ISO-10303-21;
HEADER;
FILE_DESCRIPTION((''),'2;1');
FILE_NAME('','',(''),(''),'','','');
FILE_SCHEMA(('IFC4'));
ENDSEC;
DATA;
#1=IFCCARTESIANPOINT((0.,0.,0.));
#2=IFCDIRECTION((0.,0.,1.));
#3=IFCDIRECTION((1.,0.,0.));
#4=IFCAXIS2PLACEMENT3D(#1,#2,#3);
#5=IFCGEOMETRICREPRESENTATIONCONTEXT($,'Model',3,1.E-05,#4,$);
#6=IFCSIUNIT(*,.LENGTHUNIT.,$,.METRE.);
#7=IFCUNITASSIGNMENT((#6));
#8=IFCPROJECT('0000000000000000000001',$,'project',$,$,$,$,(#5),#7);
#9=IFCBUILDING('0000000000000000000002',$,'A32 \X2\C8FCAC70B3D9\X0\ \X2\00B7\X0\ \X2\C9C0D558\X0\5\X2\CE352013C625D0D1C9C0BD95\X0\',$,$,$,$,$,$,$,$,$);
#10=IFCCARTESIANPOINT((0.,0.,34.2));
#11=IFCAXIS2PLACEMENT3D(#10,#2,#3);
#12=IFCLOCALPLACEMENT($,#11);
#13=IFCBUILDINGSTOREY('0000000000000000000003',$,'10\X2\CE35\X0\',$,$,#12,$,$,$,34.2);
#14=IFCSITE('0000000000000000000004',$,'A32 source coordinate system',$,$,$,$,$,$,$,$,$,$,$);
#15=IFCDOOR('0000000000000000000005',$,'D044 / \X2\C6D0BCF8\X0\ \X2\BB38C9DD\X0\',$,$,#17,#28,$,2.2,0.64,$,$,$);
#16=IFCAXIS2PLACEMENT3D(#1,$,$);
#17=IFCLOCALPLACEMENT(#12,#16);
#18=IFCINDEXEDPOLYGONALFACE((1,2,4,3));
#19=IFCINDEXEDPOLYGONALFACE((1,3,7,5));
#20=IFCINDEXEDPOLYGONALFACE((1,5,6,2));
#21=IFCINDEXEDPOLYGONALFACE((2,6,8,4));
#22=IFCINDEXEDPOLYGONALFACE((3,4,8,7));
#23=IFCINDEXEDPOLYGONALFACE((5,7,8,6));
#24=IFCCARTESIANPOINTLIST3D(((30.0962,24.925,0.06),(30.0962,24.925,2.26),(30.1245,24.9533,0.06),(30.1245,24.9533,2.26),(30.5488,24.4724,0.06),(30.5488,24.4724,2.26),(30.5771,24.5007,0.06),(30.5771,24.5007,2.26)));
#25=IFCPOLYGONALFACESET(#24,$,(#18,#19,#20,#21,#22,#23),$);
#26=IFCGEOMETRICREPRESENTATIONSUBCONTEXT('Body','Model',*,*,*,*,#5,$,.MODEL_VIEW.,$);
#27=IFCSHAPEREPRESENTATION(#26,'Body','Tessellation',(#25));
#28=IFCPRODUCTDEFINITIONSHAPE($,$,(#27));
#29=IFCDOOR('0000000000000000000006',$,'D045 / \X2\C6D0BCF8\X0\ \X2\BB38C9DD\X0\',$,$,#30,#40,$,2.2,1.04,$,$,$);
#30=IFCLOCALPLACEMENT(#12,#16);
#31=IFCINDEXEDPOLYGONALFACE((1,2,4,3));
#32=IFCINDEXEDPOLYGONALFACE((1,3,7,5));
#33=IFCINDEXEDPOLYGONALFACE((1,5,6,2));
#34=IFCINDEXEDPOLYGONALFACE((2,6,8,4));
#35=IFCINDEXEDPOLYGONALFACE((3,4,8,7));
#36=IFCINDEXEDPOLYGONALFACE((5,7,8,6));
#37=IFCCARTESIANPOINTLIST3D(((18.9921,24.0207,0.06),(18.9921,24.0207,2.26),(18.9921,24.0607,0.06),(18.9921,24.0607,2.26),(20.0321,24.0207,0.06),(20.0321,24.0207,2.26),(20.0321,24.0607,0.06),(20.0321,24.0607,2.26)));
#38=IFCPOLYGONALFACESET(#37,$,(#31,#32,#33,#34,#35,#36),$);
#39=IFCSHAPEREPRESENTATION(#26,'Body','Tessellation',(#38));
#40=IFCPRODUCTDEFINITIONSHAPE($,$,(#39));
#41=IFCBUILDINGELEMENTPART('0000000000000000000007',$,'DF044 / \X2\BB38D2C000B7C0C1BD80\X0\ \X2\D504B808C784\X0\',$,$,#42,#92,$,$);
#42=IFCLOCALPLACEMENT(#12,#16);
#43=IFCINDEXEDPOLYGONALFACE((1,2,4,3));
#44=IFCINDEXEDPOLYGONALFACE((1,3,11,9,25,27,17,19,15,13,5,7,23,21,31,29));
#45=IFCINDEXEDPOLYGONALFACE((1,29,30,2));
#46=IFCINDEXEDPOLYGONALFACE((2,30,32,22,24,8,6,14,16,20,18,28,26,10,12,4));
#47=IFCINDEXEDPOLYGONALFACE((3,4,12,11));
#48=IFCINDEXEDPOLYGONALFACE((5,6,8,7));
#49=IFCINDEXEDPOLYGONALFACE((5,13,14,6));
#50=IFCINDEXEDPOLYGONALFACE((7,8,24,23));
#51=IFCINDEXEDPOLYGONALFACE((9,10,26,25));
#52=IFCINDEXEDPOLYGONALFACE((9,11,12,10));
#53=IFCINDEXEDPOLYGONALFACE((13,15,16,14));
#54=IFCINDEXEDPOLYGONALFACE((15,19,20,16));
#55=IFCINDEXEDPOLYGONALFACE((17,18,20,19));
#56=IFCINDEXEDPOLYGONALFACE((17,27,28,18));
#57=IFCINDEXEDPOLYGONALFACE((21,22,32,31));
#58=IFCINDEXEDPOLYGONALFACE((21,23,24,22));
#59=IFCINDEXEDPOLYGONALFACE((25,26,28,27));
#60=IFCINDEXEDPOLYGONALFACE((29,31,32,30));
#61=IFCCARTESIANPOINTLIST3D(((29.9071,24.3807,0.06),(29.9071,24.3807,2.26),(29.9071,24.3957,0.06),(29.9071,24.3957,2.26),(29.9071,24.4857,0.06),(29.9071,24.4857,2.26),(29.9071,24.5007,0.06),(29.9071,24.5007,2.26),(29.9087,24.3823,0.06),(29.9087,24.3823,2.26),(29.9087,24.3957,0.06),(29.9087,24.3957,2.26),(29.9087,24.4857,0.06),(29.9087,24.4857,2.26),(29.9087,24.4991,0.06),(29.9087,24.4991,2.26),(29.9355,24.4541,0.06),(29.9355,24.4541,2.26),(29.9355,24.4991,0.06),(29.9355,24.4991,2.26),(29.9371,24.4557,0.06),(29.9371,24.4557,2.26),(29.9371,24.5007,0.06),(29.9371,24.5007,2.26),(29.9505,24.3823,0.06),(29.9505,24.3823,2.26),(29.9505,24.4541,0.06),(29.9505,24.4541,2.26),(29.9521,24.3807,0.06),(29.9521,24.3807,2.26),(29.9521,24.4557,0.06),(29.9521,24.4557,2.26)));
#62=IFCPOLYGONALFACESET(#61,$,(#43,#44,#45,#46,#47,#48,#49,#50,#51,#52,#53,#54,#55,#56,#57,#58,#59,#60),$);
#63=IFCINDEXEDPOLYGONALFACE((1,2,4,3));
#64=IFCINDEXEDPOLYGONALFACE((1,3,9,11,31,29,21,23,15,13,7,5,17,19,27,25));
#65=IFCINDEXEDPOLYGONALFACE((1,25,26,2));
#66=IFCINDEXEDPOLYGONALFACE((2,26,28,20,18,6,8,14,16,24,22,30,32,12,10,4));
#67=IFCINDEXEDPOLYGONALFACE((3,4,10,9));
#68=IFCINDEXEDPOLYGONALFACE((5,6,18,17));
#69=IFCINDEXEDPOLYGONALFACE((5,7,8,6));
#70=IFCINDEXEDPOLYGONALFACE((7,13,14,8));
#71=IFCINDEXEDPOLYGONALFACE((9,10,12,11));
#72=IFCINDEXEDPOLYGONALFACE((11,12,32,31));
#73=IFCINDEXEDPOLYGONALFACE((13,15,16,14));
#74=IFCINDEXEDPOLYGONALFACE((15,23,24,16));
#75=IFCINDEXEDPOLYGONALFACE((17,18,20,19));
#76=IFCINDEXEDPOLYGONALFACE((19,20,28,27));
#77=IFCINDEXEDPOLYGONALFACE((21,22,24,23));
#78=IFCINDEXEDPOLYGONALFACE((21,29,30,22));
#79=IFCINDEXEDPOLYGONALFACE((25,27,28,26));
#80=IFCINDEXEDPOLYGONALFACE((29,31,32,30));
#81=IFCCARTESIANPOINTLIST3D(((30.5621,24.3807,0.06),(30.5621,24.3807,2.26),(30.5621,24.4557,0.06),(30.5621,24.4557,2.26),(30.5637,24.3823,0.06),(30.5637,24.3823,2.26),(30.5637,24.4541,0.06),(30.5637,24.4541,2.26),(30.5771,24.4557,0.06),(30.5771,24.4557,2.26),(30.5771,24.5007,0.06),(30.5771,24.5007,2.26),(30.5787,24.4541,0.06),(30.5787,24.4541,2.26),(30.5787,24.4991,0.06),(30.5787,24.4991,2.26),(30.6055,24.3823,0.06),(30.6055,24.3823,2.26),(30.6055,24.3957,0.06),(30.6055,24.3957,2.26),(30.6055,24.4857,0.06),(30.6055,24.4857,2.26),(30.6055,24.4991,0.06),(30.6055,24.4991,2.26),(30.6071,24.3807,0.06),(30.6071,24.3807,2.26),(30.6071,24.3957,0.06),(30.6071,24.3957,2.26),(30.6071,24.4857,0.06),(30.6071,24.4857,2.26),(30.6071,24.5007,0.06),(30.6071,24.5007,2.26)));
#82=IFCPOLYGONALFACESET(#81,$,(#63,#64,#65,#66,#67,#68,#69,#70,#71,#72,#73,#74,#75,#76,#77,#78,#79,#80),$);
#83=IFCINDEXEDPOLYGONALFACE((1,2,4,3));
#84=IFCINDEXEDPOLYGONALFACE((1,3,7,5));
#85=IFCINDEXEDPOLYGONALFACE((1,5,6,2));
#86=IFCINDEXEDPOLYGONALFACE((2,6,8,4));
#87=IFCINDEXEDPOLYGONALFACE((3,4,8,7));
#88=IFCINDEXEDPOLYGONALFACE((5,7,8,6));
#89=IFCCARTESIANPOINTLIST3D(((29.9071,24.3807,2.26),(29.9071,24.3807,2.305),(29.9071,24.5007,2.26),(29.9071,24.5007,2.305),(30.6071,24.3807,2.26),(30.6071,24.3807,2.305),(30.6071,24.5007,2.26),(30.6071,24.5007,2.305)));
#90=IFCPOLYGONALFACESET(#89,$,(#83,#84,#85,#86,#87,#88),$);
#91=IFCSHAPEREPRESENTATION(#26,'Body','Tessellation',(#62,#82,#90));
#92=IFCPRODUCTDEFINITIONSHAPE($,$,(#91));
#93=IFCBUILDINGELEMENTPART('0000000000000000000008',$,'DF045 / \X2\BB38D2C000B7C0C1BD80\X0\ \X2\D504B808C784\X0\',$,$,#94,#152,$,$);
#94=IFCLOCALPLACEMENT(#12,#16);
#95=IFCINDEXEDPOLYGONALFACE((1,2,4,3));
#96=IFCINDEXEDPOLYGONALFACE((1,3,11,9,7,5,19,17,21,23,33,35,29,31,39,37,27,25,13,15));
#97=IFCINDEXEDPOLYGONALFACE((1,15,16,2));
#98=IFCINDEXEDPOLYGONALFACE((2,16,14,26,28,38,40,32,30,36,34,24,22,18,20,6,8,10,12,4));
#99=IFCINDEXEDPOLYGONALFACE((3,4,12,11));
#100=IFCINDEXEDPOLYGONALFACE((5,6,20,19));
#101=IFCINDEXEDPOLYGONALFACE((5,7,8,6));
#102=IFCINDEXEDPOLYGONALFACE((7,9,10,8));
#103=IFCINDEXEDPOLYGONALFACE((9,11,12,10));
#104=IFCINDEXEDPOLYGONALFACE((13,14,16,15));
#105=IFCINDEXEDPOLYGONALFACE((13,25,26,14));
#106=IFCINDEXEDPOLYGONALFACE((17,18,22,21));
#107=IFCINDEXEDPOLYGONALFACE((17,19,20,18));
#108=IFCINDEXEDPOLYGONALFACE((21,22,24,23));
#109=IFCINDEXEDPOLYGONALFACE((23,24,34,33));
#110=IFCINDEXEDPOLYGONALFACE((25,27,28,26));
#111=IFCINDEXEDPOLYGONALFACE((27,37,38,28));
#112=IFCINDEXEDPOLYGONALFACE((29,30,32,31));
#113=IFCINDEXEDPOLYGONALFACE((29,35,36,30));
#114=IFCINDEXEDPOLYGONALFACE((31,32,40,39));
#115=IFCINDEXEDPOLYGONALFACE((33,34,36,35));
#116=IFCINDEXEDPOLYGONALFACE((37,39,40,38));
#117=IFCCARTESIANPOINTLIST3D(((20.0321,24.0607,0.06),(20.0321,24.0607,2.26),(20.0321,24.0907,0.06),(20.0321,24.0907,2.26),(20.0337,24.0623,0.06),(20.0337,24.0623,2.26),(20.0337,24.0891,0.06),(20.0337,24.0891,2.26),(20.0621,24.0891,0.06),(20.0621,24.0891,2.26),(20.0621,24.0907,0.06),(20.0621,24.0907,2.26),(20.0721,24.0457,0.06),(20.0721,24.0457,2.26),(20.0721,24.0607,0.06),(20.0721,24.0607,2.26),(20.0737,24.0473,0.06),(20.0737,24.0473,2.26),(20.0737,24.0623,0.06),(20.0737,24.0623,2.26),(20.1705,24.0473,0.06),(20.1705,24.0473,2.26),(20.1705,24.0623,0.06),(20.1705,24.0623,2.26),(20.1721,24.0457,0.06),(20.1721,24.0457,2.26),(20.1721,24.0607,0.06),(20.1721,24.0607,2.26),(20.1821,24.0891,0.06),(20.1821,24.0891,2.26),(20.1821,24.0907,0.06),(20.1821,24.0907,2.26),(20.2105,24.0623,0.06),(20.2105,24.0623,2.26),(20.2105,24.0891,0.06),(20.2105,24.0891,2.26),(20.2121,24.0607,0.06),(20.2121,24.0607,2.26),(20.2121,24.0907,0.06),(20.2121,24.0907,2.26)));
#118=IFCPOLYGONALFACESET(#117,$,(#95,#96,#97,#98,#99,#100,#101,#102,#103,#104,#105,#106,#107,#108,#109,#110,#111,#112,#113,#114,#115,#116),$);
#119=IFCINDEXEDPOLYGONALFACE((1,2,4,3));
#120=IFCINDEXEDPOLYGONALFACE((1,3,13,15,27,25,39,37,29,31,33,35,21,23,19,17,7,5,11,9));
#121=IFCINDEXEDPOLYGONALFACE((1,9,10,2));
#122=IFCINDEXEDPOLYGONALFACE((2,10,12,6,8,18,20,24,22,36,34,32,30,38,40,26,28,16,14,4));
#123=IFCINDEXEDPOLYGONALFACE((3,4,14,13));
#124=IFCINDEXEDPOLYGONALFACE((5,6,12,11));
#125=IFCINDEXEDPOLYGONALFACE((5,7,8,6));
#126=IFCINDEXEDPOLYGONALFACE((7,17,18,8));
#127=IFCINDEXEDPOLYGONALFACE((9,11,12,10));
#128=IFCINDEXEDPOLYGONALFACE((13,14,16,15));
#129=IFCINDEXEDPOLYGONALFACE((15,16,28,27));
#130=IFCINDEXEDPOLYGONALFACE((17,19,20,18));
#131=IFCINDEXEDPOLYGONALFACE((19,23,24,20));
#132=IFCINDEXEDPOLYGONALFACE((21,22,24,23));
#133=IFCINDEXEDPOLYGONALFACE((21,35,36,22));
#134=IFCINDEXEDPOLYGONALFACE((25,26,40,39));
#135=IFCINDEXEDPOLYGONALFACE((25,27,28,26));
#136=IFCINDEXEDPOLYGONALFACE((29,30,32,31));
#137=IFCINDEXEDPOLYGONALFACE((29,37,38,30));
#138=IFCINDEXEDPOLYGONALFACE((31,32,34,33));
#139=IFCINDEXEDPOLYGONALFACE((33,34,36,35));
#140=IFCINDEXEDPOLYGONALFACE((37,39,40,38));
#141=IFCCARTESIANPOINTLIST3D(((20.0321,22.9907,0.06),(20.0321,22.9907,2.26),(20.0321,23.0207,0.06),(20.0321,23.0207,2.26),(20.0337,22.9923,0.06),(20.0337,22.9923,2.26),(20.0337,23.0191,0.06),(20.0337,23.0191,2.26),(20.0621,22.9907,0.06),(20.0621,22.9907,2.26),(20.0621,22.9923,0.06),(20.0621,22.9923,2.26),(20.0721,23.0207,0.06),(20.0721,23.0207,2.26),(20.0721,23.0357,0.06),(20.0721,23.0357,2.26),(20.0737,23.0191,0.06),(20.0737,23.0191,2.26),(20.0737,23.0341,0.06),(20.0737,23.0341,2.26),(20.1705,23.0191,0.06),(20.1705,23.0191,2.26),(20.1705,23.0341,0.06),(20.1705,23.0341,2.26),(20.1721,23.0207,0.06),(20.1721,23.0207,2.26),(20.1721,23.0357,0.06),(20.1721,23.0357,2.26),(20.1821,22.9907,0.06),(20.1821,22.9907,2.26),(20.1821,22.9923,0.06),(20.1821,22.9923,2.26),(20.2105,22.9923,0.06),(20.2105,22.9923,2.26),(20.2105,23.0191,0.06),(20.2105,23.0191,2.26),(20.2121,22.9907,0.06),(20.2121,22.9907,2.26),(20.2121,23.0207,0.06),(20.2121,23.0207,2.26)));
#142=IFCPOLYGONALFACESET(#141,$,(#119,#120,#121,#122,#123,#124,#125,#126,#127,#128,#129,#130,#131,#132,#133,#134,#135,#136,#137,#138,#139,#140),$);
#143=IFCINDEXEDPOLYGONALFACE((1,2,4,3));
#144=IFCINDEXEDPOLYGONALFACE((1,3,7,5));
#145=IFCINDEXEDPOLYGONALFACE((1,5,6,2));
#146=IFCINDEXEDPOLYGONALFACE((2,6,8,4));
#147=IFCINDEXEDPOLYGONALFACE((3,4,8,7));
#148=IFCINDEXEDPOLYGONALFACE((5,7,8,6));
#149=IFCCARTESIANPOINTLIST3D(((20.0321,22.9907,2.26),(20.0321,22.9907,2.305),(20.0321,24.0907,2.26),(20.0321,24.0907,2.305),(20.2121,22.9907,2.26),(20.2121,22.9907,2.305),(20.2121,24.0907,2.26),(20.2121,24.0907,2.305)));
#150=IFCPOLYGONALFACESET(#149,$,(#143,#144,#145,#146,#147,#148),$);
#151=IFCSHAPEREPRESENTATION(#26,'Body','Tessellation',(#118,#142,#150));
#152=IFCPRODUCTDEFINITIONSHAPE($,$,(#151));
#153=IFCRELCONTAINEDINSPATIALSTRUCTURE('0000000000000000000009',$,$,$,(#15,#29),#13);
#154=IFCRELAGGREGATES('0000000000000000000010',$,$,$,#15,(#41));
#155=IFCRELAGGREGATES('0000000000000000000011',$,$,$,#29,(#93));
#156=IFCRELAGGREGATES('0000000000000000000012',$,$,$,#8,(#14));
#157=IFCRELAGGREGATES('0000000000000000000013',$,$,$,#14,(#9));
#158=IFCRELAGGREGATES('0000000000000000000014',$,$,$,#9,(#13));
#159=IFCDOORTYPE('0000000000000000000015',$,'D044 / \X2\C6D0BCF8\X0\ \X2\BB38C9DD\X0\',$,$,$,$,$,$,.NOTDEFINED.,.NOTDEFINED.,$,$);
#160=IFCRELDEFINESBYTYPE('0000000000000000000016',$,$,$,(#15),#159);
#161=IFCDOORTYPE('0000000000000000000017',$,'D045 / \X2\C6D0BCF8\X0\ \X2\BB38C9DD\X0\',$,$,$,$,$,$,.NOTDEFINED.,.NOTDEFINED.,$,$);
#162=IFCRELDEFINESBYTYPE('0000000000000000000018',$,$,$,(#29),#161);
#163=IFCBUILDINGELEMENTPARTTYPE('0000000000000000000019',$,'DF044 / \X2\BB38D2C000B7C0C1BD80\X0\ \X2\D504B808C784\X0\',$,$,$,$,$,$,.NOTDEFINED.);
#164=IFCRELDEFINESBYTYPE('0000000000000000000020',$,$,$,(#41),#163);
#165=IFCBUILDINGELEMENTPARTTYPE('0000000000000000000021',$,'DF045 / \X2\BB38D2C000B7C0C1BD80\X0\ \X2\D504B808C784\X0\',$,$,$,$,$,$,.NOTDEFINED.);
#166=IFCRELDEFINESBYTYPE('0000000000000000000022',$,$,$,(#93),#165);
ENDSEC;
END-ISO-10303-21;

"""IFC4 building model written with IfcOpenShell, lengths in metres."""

from ifc_helpers import new_model, si_unit, frame, origin, origin_with_axes, place, context, subcontext, project, spatial, polyline, outline, extrude, source, transform, mapped, type_object, type_shapes, element, aggregate, save


model = new_model("IFC4")

# Units and contexts
model_context = context("Model", 3, precision=1e-05, world=origin_with_axes())
body_context = subcontext(model_context, "Body", "Model", "MODEL_VIEW")
ifc_project = project(units=[si_unit("LENGTHUNIT", "METRE")], contexts=[model_context])

# Site, building, storey
storey_placement = place(None, frame((0.0, 0.0, 34.2), z_axis=(0.0, 0.0, 1.0), x_axis=(1.0, 0.0, 0.0)))
site = spatial("IfcSite", under=ifc_project, Name="A32 source coordinate system")
building = spatial("IfcBuilding", under=site, Name="A32 주거동 · 지하5층–옥탑지붕")
storey = spatial("IfcBuildingStorey", under=building, at=storey_placement, Name="10층", Elevation=34.2)

# Doors
door_type_1 = type_object("IfcDoorType", Name="D044 / 원본 문짝", OperationType="NOTDEFINED", PredefinedType="NOTDEFINED")
shared_shape_1 = source(origin(), body_context, "Body", "SweptSolid", [
    extrude(outline(polyline([(30.5771, 24.5007), (30.5488, 24.4724), (30.0962, 24.925), (30.1245, 24.9533), (30.5771, 24.5007)])), frame((0.0, 0.0, 0.06)), (0.0, 0.0, 1.0), 2.2),
])
type_shapes(door_type_1, [shared_shape_1])
door_1_placement = place(storey_placement, origin_with_axes())
door_1 = element("IfcDoor", 1, at=door_1_placement, inside=storey, type_object=door_type_1, Name="D044 / 원본 문짝", OverallHeight=2.2, OverallWidth=0.64, context=body_context, shape_type="MappedRepresentation", body=[
    mapped(shared_shape_1, transform((0.0, 0.0, 0.0), scale=1.0)),
])
door_type_2 = type_object("IfcDoorType", Name="D045 / 원본 문짝", OperationType="NOTDEFINED", PredefinedType="NOTDEFINED")
shared_shape_2 = source(origin(), body_context, "Body", "SweptSolid", [
    extrude(outline(polyline([(20.0321, 24.0607), (20.0321, 24.0207), (18.9921, 24.0207), (18.9921, 24.0607), (20.0321, 24.0607)])), frame((0.0, 0.0, 0.06)), (0.0, 0.0, 1.0), 2.2),
])
type_shapes(door_type_2, [shared_shape_2])
door_2_placement = place(storey_placement, origin_with_axes())
door_2 = element("IfcDoor", 2, at=door_2_placement, inside=storey, type_object=door_type_2, Name="D045 / 원본 문짝", OverallHeight=2.2, OverallWidth=1.04, context=body_context, shape_type="MappedRepresentation", body=[
    mapped(shared_shape_2, transform((0.0, 0.0, 0.0), scale=1.0)),
])

# Building element parts
building_element_part_type_1 = type_object("IfcBuildingElementPartType", Name="DF044 / 문틀·상부 프레임", PredefinedType="NOTDEFINED")
shared_shape_3 = source(origin(), body_context, "Body", "SweptSolid", [
    extrude(outline(polyline([(29.9071, 24.4857), (29.9071, 24.5007), (29.9371, 24.5007), (29.9371, 24.4557), (29.9521, 24.4557), (29.9521, 24.3807), (29.9071, 24.3807), (29.9071, 24.3957), (29.9087, 24.3957), (29.9087, 24.3823), (29.9505, 24.3823), (29.9505, 24.4541), (29.9355, 24.4541), (29.9355, 24.4991), (29.9087, 24.4991), (29.9087, 24.4857), (29.9071, 24.4857)])), frame((0.0, 0.0, 0.06)), (0.0, 0.0, 1.0), 2.2),
    extrude(outline(polyline([(30.6055, 24.4991), (30.5787, 24.4991), (30.5787, 24.4541), (30.5637, 24.4541), (30.5637, 24.3823), (30.6055, 24.3823), (30.6055, 24.3957), (30.6071, 24.3957), (30.6071, 24.3807), (30.5621, 24.3807), (30.5621, 24.4557), (30.5771, 24.4557), (30.5771, 24.5007), (30.6071, 24.5007), (30.6071, 24.4857), (30.6055, 24.4857), (30.6055, 24.4991)])), frame((0.0, 0.0, 0.06)), (0.0, 0.0, 1.0), 2.2),
    extrude(outline(polyline([(29.9071, 24.3807), (29.9071, 24.5007), (30.6071, 24.5007), (30.6071, 24.3807), (29.9071, 24.3807)])), frame((0.0, 0.0, 2.26)), (0.0, 0.0, 1.0), 0.045),
])
type_shapes(building_element_part_type_1, [shared_shape_3])
building_element_part_1_placement = place(door_1_placement, origin_with_axes())
building_element_part_1 = element("IfcBuildingElementPart", 3, at=building_element_part_1_placement, type_object=building_element_part_type_1, Name="DF044 / 문틀·상부 프레임", context=body_context, shape_type="MappedRepresentation", body=[
    mapped(shared_shape_3, transform((0.0, 0.0, 0.0), scale=1.0)),
])
aggregate(door_1, [building_element_part_1])
building_element_part_type_2 = type_object("IfcBuildingElementPartType", Name="DF045 / 문틀·상부 프레임", PredefinedType="NOTDEFINED")
shared_shape_4 = source(origin(), body_context, "Body", "SweptSolid", [
    extrude(outline(polyline([(20.0337, 24.0891), (20.0337, 24.0623), (20.0737, 24.0623), (20.0737, 24.0473), (20.1705, 24.0473), (20.1705, 24.0623), (20.2105, 24.0623), (20.2105, 24.0891), (20.1821, 24.0891), (20.1821, 24.0907), (20.2121, 24.0907), (20.2121, 24.0607), (20.1721, 24.0607), (20.1721, 24.0457), (20.0721, 24.0457), (20.0721, 24.0607), (20.0321, 24.0607), (20.0321, 24.0907), (20.0621, 24.0907), (20.0621, 24.0891), (20.0337, 24.0891)])), frame((0.0, 0.0, 0.06)), (0.0, 0.0, 1.0), 2.2),
    extrude(outline(polyline([(20.0621, 22.9907), (20.0321, 22.9907), (20.0321, 23.0207), (20.0721, 23.0207), (20.0721, 23.0357), (20.1721, 23.0357), (20.1721, 23.0207), (20.2121, 23.0207), (20.2121, 22.9907), (20.1821, 22.9907), (20.1821, 22.9923), (20.2105, 22.9923), (20.2105, 23.0191), (20.1705, 23.0191), (20.1705, 23.0341), (20.0737, 23.0341), (20.0737, 23.0191), (20.0337, 23.0191), (20.0337, 22.9923), (20.0621, 22.9923), (20.0621, 22.9907)])), frame((0.0, 0.0, 0.06)), (0.0, 0.0, 1.0), 2.2),
    extrude(outline(polyline([(20.0321, 22.9907), (20.0321, 24.0907), (20.2121, 24.0907), (20.2121, 22.9907), (20.0321, 22.9907)])), frame((0.0, 0.0, 2.26)), (0.0, 0.0, 1.0), 0.045),
])
type_shapes(building_element_part_type_2, [shared_shape_4])
building_element_part_2_placement = place(door_2_placement, origin_with_axes())
building_element_part_2 = element("IfcBuildingElementPart", 4, at=building_element_part_2_placement, type_object=building_element_part_type_2, Name="DF045 / 문틀·상부 프레임", context=body_context, shape_type="MappedRepresentation", body=[
    mapped(shared_shape_4, transform((0.0, 0.0, 0.0), scale=1.0)),
])
aggregate(door_2, [building_element_part_2])

save(model, "model.ifc")
